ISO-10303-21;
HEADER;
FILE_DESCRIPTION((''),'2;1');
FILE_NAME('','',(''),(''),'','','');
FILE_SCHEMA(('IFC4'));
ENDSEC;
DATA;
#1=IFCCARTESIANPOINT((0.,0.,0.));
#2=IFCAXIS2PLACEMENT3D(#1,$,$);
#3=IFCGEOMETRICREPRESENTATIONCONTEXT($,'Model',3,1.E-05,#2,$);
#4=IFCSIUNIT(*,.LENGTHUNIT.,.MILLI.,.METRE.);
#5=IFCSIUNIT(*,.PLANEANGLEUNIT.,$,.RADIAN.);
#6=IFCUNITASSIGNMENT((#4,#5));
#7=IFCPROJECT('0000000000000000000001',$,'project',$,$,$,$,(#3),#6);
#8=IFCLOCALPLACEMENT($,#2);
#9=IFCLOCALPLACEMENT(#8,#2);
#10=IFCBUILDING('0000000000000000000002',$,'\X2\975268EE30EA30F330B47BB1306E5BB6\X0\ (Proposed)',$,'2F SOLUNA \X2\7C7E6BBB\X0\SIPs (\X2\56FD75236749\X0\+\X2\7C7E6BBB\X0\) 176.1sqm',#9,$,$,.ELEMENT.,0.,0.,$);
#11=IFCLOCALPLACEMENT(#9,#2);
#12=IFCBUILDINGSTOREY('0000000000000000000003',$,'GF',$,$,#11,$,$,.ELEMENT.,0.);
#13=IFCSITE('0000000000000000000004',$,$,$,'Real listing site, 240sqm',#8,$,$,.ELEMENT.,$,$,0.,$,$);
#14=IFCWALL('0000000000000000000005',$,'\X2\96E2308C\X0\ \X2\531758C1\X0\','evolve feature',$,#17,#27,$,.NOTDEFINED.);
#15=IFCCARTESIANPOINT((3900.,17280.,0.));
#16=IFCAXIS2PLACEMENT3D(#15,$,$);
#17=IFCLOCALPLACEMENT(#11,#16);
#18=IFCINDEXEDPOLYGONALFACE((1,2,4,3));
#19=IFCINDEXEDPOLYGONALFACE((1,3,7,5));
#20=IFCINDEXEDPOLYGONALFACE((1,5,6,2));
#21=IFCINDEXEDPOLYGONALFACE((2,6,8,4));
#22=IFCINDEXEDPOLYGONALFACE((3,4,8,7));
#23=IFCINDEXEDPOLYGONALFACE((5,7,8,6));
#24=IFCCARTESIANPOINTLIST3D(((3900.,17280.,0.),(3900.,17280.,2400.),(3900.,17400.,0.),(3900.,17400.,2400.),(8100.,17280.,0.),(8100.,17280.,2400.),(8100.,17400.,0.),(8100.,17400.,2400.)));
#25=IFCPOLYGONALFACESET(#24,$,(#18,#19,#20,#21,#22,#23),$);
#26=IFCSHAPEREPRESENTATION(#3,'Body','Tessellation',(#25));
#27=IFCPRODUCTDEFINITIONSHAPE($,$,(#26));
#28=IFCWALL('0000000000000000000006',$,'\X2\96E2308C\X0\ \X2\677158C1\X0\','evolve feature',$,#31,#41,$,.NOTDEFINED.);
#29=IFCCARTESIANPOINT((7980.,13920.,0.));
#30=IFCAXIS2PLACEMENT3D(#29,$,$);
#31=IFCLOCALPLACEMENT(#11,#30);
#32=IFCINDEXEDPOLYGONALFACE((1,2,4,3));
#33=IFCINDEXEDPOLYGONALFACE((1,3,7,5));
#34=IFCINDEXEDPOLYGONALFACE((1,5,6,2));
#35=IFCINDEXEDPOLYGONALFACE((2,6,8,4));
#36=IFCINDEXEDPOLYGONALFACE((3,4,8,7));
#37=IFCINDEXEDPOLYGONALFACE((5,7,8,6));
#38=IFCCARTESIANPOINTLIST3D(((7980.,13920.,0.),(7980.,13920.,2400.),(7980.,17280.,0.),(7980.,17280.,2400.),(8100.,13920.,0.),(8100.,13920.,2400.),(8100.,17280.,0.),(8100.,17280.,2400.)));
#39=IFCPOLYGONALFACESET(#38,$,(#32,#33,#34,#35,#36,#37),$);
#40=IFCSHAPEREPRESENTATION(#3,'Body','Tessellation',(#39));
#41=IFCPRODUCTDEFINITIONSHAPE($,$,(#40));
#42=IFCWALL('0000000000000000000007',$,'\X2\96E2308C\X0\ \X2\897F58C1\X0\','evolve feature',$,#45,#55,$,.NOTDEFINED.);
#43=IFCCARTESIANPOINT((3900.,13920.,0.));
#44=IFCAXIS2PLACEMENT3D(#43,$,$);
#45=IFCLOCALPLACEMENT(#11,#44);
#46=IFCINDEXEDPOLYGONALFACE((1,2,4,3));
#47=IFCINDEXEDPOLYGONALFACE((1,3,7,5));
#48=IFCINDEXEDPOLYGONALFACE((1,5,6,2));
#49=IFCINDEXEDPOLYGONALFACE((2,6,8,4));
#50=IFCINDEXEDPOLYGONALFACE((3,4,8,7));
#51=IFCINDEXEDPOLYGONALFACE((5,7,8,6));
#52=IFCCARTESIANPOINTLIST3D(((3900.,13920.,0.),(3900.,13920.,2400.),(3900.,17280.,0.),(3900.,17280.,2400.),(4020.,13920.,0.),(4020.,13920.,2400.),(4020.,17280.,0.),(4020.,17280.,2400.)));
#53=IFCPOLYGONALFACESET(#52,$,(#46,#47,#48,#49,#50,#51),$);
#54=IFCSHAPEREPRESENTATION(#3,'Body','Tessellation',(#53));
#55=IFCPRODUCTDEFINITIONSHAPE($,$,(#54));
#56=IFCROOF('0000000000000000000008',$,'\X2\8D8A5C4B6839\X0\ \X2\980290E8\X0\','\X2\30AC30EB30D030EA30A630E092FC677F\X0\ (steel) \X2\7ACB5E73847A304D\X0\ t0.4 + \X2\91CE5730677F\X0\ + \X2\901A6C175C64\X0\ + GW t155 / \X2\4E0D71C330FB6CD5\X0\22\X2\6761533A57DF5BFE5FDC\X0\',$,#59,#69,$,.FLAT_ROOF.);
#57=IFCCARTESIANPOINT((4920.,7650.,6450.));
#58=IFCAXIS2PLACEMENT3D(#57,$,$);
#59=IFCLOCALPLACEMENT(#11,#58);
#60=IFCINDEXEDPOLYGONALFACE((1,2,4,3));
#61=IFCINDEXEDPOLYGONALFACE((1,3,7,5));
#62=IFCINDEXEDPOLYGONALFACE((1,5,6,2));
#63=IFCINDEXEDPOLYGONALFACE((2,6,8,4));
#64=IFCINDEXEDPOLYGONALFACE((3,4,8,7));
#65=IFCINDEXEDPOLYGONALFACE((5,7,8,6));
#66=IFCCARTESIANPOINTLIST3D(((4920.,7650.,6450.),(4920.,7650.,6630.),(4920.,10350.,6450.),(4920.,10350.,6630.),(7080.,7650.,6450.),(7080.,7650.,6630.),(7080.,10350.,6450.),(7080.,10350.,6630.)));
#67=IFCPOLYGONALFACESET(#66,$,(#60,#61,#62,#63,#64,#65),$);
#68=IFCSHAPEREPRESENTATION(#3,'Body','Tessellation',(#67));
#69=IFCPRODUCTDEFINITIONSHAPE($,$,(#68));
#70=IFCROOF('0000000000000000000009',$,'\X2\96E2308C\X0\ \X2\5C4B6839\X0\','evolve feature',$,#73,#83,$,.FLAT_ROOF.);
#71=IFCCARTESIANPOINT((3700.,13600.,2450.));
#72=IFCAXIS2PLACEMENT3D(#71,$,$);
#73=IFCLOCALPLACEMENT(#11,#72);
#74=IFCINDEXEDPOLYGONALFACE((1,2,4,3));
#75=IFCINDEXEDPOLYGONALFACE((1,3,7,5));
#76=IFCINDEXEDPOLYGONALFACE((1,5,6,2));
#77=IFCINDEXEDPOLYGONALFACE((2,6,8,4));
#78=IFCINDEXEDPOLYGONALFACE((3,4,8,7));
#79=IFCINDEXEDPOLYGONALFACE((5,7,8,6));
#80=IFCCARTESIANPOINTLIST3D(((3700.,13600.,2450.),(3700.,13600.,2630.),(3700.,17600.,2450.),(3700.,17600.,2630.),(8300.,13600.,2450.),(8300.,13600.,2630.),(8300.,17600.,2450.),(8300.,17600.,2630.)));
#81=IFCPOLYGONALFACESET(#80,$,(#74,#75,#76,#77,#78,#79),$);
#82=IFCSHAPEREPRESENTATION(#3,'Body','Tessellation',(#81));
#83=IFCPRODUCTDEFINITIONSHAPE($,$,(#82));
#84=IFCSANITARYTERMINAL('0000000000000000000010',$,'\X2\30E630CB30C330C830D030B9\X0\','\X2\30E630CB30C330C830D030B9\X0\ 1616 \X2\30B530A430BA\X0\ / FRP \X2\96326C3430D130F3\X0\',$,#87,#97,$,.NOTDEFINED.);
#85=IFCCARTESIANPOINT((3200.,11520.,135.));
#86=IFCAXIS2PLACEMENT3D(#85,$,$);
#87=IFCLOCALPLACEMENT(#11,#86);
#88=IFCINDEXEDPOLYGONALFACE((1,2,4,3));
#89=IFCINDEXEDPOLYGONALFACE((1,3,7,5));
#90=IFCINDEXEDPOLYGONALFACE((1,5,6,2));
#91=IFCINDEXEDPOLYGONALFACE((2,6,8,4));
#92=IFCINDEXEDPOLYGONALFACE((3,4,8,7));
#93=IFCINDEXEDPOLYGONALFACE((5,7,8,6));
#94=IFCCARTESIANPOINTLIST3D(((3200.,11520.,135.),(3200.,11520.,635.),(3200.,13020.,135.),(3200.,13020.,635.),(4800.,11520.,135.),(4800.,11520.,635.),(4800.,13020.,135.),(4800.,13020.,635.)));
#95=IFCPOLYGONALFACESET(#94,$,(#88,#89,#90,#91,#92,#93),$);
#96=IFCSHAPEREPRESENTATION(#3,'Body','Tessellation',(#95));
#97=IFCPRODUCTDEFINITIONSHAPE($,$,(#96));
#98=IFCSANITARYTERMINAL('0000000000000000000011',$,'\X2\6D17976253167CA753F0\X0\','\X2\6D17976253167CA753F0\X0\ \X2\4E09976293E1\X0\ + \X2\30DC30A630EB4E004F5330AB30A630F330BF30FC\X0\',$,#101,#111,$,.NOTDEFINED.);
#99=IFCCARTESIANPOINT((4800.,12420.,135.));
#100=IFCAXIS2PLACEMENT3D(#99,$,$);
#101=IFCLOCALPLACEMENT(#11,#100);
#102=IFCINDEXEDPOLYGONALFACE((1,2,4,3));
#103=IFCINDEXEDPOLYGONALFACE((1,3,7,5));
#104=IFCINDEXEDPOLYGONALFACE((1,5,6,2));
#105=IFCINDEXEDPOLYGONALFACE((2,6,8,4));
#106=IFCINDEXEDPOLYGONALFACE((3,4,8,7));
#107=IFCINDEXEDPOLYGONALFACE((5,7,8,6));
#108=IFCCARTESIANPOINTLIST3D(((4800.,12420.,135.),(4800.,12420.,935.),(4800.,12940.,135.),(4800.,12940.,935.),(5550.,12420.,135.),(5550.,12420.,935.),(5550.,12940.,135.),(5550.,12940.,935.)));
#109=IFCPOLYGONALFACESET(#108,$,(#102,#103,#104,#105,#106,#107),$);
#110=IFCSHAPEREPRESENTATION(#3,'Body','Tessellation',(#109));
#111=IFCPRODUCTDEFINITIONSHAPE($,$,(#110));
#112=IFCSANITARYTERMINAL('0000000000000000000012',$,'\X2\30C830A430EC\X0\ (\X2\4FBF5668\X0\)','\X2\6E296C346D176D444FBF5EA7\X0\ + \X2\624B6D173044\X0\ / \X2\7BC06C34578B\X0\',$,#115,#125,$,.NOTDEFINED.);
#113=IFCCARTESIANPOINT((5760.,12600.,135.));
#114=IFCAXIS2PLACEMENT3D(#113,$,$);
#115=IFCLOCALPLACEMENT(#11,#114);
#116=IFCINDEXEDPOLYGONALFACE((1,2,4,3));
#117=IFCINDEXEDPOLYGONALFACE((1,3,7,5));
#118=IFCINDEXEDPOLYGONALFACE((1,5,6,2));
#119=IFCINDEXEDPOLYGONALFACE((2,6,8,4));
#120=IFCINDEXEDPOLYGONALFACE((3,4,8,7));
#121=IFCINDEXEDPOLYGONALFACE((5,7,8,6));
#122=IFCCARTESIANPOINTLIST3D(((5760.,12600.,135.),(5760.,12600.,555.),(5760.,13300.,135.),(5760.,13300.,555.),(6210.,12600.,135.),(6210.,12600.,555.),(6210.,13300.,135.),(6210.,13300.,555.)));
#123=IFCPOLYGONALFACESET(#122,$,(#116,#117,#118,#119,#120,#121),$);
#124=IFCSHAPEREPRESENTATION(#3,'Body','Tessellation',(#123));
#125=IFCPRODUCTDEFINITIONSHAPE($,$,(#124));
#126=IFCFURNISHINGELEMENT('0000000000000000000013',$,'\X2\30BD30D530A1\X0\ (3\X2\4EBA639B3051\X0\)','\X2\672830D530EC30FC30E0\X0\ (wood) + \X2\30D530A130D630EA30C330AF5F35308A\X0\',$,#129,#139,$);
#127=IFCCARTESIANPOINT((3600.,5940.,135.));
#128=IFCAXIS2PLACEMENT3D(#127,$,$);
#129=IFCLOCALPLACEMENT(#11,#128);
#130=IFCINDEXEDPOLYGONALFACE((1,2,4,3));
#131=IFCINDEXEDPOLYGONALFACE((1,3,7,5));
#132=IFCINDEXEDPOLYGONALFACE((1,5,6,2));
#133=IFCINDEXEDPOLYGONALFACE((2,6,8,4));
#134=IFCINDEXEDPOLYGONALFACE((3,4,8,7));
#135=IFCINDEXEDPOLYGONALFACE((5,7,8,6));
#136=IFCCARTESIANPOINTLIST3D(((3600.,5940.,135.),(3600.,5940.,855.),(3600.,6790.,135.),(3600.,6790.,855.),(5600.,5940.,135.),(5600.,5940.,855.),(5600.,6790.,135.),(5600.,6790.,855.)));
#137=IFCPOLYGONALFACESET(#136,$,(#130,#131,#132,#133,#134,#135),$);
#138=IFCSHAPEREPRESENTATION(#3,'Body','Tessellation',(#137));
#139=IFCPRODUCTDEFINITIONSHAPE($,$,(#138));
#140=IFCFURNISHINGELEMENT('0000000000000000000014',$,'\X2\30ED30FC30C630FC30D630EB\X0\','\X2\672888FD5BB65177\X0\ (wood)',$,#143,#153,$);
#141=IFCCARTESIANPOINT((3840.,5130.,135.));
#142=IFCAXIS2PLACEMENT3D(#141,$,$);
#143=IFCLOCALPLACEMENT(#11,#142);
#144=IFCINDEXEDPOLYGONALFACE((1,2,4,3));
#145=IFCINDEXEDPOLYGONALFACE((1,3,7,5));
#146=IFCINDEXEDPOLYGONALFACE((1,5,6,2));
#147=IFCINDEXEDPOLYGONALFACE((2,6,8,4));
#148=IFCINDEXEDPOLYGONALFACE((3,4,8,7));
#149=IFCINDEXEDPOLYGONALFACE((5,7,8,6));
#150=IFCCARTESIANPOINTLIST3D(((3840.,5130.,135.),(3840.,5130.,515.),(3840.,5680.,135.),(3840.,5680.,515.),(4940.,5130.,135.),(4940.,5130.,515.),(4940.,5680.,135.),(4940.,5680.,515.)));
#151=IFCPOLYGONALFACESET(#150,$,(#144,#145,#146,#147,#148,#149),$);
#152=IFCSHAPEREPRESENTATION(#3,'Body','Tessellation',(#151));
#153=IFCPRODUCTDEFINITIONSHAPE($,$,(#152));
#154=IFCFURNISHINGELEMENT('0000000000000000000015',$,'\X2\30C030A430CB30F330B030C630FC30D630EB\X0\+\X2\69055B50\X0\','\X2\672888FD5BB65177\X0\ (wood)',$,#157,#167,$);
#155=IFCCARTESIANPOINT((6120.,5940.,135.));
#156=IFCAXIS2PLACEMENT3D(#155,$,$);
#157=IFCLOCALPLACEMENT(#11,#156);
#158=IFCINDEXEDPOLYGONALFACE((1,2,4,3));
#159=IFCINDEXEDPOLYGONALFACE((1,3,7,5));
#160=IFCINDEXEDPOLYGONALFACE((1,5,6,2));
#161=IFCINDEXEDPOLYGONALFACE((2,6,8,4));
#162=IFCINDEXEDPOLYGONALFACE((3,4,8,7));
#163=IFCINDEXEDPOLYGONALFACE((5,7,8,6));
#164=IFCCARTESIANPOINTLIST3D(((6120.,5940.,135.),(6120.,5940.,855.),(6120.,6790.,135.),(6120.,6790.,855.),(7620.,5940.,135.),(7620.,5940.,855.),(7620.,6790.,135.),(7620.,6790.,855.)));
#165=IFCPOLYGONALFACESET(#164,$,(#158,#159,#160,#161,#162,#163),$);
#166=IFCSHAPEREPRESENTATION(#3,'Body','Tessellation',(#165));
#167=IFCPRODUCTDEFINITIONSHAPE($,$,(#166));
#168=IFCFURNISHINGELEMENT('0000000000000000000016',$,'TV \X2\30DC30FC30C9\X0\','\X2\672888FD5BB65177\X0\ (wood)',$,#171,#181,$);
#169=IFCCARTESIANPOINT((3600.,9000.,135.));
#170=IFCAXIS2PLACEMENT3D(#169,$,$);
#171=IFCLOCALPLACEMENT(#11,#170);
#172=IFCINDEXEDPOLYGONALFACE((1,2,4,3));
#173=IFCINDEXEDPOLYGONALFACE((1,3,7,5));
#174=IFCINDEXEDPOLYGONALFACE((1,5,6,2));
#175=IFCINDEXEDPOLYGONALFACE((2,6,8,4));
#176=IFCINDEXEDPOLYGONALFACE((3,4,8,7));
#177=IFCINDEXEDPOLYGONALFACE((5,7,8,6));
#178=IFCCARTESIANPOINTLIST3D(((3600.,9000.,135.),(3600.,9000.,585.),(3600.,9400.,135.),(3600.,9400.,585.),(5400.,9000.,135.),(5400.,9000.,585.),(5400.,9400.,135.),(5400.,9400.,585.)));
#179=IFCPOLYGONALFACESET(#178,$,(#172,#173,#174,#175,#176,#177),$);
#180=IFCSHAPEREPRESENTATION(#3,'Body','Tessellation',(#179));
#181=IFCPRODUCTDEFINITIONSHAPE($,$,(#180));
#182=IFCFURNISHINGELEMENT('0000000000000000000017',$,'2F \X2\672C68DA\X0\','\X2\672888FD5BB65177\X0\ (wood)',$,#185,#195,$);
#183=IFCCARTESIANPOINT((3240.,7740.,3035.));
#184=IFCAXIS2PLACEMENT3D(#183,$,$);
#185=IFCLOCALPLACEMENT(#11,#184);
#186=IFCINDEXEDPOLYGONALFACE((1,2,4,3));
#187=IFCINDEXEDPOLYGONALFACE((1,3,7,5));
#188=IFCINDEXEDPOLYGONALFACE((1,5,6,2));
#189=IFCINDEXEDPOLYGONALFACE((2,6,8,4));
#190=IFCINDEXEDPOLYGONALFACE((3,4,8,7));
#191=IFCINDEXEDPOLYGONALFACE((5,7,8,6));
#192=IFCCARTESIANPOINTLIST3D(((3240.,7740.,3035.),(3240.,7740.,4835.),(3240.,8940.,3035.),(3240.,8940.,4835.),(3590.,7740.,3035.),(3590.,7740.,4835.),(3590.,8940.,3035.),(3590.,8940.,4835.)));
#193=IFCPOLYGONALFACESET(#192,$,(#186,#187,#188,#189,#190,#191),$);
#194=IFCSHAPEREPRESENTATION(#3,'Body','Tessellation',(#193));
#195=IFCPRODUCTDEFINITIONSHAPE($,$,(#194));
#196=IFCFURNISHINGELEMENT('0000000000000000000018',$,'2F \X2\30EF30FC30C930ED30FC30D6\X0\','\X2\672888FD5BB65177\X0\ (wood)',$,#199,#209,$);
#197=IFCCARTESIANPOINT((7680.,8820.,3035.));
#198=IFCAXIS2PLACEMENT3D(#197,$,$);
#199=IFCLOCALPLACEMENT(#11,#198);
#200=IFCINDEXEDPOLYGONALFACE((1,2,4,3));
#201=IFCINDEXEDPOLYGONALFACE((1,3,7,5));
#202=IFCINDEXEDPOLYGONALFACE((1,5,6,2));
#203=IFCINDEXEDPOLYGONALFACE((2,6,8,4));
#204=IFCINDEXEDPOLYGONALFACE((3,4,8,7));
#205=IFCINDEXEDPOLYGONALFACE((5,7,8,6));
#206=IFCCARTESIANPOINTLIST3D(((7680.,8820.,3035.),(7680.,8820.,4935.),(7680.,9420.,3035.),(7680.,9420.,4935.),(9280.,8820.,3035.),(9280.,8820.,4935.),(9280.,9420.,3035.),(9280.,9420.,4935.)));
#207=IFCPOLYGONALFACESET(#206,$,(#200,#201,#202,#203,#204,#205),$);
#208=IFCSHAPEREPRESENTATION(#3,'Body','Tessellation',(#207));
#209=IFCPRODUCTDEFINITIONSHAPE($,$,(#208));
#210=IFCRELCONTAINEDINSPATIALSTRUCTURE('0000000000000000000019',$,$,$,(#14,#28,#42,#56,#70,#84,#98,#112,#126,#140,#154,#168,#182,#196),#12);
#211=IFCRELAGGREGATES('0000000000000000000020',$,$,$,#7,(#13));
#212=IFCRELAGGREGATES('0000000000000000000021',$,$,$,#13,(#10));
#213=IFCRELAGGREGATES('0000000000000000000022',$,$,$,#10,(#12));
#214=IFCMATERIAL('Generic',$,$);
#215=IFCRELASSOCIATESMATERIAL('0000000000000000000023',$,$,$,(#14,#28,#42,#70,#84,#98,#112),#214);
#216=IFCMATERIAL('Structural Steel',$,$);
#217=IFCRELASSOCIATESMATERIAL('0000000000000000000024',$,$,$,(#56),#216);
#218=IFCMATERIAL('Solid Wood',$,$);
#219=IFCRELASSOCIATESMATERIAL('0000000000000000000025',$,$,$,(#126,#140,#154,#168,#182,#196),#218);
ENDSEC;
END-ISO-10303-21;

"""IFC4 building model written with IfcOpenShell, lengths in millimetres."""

from ifc_helpers import new_model, si_unit, frame, frame_2d, origin, place, context, project, spatial, rectangle, extrude, material, element, save


model = new_model("IFC4")

# Units and contexts
model_context = context("Model", 3, precision=1e-05, world=origin())
ifc_project = project(units=[si_unit("LENGTHUNIT", "METRE", prefix="MILLI"), si_unit("PLANEANGLEUNIT", "RADIAN")], contexts=[model_context])

# Site, building, storey
site_placement = place(None, origin())
site = spatial("IfcSite", under=ifc_project, at=site_placement, ObjectType="Real listing site, 240sqm", CompositionType="ELEMENT", RefElevation=0.0)
building_placement = place(site_placement, origin())
building = spatial("IfcBuilding", under=site, at=building_placement, Name="青森リンゴ箱の家 (Proposed)", ObjectType="2F SOLUNA 籾殻SIPs (国産杉+籾殻) 176.1sqm", CompositionType="ELEMENT", ElevationOfRefHeight=0.0, ElevationOfTerrain=0.0)
storey_placement = place(building_placement, origin())
storey = spatial("IfcBuildingStorey", under=building, at=storey_placement, Name="GF", CompositionType="ELEMENT", Elevation=0.0)

# Shared definitions
ifc_material_1 = material(Name="Generic")

# Shared definitions
ifc_material_2 = material(Name="Solid Wood")

# Walls
wall_1_placement = place(storey_placement, frame((3900.0, 17280.0, 0.0)))
element("IfcWall", 1, at=wall_1_placement, inside=storey, material=ifc_material_1, Name="離れ 北壁", Description="evolve feature", PredefinedType="NOTDEFINED", context=model_context, shape_type="SweptSolid", body=[
    extrude(rectangle(XDim=4200.0, YDim=120.0, at=frame_2d((2100.0, 60.0))), frame((3900.0, 17280.0, 0.0)), (0.0, 0.0, 1.0), 2400.0),
])
wall_2_placement = place(storey_placement, frame((7980.0, 13920.0, 0.0)))
element("IfcWall", 2, at=wall_2_placement, inside=storey, material=ifc_material_1, Name="離れ 東壁", Description="evolve feature", PredefinedType="NOTDEFINED", context=model_context, shape_type="SweptSolid", body=[
    extrude(rectangle(XDim=120.0, YDim=3360.0, at=frame_2d((60.0, 1680.0))), frame((7980.0, 13920.0, 0.0)), (0.0, 0.0, 1.0), 2400.0),
])
wall_3_placement = place(storey_placement, frame((3900.0, 13920.0, 0.0)))
element("IfcWall", 3, at=wall_3_placement, inside=storey, material=ifc_material_1, Name="離れ 西壁", Description="evolve feature", PredefinedType="NOTDEFINED", context=model_context, shape_type="SweptSolid", body=[
    extrude(rectangle(XDim=120.0, YDim=3360.0, at=frame_2d((60.0, 1680.0))), frame((3900.0, 13920.0, 0.0)), (0.0, 0.0, 1.0), 2400.0),
])

# Roofs
ifc_material_3 = material(Name="Structural Steel")
roof_1_placement = place(storey_placement, frame((4920.0, 7650.0, 6450.0)))
element("IfcRoof", 4, at=roof_1_placement, inside=storey, material=ifc_material_3, Name="越屋根 頂部", Description="ガルバリウム鋼板 (steel) 立平葺き t0.4 + 野地板 + 通気層 + GW t155 / 不燃・法22条区域対応", PredefinedType="FLAT_ROOF", context=model_context, shape_type="SweptSolid", body=[
    extrude(rectangle(XDim=2160.0, YDim=2700.0, at=frame_2d((1080.0, 1350.0))), frame((4920.0, 7650.0, 6450.0)), (0.0, 0.0, 1.0), 180.0),
])
roof_2_placement = place(storey_placement, frame((3700.0, 13600.0, 2450.0)))
element("IfcRoof", 5, at=roof_2_placement, inside=storey, material=ifc_material_1, Name="離れ 屋根", Description="evolve feature", PredefinedType="FLAT_ROOF", context=model_context, shape_type="SweptSolid", body=[
    extrude(rectangle(XDim=4600.0, YDim=4000.0, at=frame_2d((2300.0, 2000.0))), frame((3700.0, 13600.0, 2450.0)), (0.0, 0.0, 1.0), 180.0),
])

# Sanitary terminals
sanitary_terminal_1_placement = place(storey_placement, frame((3200.0, 11520.0, 135.0)))
element("IfcSanitaryTerminal", 6, at=sanitary_terminal_1_placement, inside=storey, material=ifc_material_1, Name="ユニットバス", Description="ユニットバス 1616 サイズ / FRP 防水パン", PredefinedType="NOTDEFINED", context=model_context, shape_type="SweptSolid", body=[
    extrude(rectangle(XDim=1600.0, YDim=1500.0, at=frame_2d((800.0, 750.0))), frame((3200.0, 11520.0, 135.0)), (0.0, 0.0, 1.0), 500.0),
])
sanitary_terminal_2_placement = place(storey_placement, frame((4800.0, 12420.0, 135.0)))
element("IfcSanitaryTerminal", 7, at=sanitary_terminal_2_placement, inside=storey, material=ifc_material_1, Name="洗面化粧台", Description="洗面化粧台 三面鏡 + ボウル一体カウンター", PredefinedType="NOTDEFINED", context=model_context, shape_type="SweptSolid", body=[
    extrude(rectangle(XDim=750.0, YDim=520.0, at=frame_2d((375.0, 260.0))), frame((4800.0, 12420.0, 135.0)), (0.0, 0.0, 1.0), 800.0),
])
sanitary_terminal_3_placement = place(storey_placement, frame((5760.0, 12600.0, 135.0)))
element("IfcSanitaryTerminal", 8, at=sanitary_terminal_3_placement, inside=storey, material=ifc_material_1, Name="トイレ (便器)", Description="温水洗浄便座 + 手洗い / 節水型", PredefinedType="NOTDEFINED", context=model_context, shape_type="SweptSolid", body=[
    extrude(rectangle(XDim=450.0, YDim=700.0, at=frame_2d((225.0, 350.0))), frame((5760.0, 12600.0, 135.0)), (0.0, 0.0, 1.0), 420.0),
])

# Furnishing elements
furnishing_1_placement = place(storey_placement, frame((3600.0, 5940.0, 135.0)))
element("IfcFurnishingElement", 9, at=furnishing_1_placement, inside=storey, material=ifc_material_2, Name="ソファ (3人掛け)", Description="木フレーム (wood) + ファブリック張り", context=model_context, shape_type="SweptSolid", body=[
    extrude(rectangle(XDim=2000.0, YDim=850.0, at=frame_2d((1000.0, 425.0))), frame((3600.0, 5940.0, 135.0)), (0.0, 0.0, 1.0), 720.0),
])
furnishing_2_placement = place(storey_placement, frame((3840.0, 5130.0, 135.0)))
element("IfcFurnishingElement", 10, at=furnishing_2_placement, inside=storey, material=ifc_material_2, Name="ローテーブル", Description="木製家具 (wood)", context=model_context, shape_type="SweptSolid", body=[
    extrude(rectangle(XDim=1100.0, YDim=550.0, at=frame_2d((550.0, 275.0))), frame((3840.0, 5130.0, 135.0)), (0.0, 0.0, 1.0), 380.0),
])
furnishing_3_placement = place(storey_placement, frame((6120.0, 5940.0, 135.0)))
element("IfcFurnishingElement", 11, at=furnishing_3_placement, inside=storey, material=ifc_material_2, Name="ダイニングテーブル+椅子", Description="木製家具 (wood)", context=model_context, shape_type="SweptSolid", body=[
    extrude(rectangle(XDim=1500.0, YDim=850.0, at=frame_2d((750.0, 425.0))), frame((6120.0, 5940.0, 135.0)), (0.0, 0.0, 1.0), 720.0),
])
furnishing_4_placement = place(storey_placement, frame((3600.0, 9000.0, 135.0)))
element("IfcFurnishingElement", 12, at=furnishing_4_placement, inside=storey, material=ifc_material_2, Name="TV ボード", Description="木製家具 (wood)", context=model_context, shape_type="SweptSolid", body=[
    extrude(rectangle(XDim=1800.0, YDim=400.0, at=frame_2d((900.0, 200.0))), frame((3600.0, 9000.0, 135.0)), (0.0, 0.0, 1.0), 450.0),
])
furnishing_5_placement = place(storey_placement, frame((3240.0, 7740.0, 3035.0)))
element("IfcFurnishingElement", 13, at=furnishing_5_placement, inside=storey, material=ifc_material_2, Name="2F 本棚", Description="木製家具 (wood)", context=model_context, shape_type="SweptSolid", body=[
    extrude(rectangle(XDim=350.0, YDim=1200.0, at=frame_2d((175.0, 600.0))), frame((3240.0, 7740.0, 3035.0)), (0.0, 0.0, 1.0), 1800.0),
])
furnishing_6_placement = place(storey_placement, frame((7680.0, 8820.0, 3035.0)))
element("IfcFurnishingElement", 14, at=furnishing_6_placement, inside=storey, material=ifc_material_2, Name="2F ワードローブ", Description="木製家具 (wood)", context=model_context, shape_type="SweptSolid", body=[
    extrude(rectangle(XDim=1600.0, YDim=600.0, at=frame_2d((800.0, 300.0))), frame((7680.0, 8820.0, 3035.0)), (0.0, 0.0, 1.0), 1900.0),
])

save(model, "model.ifc")
